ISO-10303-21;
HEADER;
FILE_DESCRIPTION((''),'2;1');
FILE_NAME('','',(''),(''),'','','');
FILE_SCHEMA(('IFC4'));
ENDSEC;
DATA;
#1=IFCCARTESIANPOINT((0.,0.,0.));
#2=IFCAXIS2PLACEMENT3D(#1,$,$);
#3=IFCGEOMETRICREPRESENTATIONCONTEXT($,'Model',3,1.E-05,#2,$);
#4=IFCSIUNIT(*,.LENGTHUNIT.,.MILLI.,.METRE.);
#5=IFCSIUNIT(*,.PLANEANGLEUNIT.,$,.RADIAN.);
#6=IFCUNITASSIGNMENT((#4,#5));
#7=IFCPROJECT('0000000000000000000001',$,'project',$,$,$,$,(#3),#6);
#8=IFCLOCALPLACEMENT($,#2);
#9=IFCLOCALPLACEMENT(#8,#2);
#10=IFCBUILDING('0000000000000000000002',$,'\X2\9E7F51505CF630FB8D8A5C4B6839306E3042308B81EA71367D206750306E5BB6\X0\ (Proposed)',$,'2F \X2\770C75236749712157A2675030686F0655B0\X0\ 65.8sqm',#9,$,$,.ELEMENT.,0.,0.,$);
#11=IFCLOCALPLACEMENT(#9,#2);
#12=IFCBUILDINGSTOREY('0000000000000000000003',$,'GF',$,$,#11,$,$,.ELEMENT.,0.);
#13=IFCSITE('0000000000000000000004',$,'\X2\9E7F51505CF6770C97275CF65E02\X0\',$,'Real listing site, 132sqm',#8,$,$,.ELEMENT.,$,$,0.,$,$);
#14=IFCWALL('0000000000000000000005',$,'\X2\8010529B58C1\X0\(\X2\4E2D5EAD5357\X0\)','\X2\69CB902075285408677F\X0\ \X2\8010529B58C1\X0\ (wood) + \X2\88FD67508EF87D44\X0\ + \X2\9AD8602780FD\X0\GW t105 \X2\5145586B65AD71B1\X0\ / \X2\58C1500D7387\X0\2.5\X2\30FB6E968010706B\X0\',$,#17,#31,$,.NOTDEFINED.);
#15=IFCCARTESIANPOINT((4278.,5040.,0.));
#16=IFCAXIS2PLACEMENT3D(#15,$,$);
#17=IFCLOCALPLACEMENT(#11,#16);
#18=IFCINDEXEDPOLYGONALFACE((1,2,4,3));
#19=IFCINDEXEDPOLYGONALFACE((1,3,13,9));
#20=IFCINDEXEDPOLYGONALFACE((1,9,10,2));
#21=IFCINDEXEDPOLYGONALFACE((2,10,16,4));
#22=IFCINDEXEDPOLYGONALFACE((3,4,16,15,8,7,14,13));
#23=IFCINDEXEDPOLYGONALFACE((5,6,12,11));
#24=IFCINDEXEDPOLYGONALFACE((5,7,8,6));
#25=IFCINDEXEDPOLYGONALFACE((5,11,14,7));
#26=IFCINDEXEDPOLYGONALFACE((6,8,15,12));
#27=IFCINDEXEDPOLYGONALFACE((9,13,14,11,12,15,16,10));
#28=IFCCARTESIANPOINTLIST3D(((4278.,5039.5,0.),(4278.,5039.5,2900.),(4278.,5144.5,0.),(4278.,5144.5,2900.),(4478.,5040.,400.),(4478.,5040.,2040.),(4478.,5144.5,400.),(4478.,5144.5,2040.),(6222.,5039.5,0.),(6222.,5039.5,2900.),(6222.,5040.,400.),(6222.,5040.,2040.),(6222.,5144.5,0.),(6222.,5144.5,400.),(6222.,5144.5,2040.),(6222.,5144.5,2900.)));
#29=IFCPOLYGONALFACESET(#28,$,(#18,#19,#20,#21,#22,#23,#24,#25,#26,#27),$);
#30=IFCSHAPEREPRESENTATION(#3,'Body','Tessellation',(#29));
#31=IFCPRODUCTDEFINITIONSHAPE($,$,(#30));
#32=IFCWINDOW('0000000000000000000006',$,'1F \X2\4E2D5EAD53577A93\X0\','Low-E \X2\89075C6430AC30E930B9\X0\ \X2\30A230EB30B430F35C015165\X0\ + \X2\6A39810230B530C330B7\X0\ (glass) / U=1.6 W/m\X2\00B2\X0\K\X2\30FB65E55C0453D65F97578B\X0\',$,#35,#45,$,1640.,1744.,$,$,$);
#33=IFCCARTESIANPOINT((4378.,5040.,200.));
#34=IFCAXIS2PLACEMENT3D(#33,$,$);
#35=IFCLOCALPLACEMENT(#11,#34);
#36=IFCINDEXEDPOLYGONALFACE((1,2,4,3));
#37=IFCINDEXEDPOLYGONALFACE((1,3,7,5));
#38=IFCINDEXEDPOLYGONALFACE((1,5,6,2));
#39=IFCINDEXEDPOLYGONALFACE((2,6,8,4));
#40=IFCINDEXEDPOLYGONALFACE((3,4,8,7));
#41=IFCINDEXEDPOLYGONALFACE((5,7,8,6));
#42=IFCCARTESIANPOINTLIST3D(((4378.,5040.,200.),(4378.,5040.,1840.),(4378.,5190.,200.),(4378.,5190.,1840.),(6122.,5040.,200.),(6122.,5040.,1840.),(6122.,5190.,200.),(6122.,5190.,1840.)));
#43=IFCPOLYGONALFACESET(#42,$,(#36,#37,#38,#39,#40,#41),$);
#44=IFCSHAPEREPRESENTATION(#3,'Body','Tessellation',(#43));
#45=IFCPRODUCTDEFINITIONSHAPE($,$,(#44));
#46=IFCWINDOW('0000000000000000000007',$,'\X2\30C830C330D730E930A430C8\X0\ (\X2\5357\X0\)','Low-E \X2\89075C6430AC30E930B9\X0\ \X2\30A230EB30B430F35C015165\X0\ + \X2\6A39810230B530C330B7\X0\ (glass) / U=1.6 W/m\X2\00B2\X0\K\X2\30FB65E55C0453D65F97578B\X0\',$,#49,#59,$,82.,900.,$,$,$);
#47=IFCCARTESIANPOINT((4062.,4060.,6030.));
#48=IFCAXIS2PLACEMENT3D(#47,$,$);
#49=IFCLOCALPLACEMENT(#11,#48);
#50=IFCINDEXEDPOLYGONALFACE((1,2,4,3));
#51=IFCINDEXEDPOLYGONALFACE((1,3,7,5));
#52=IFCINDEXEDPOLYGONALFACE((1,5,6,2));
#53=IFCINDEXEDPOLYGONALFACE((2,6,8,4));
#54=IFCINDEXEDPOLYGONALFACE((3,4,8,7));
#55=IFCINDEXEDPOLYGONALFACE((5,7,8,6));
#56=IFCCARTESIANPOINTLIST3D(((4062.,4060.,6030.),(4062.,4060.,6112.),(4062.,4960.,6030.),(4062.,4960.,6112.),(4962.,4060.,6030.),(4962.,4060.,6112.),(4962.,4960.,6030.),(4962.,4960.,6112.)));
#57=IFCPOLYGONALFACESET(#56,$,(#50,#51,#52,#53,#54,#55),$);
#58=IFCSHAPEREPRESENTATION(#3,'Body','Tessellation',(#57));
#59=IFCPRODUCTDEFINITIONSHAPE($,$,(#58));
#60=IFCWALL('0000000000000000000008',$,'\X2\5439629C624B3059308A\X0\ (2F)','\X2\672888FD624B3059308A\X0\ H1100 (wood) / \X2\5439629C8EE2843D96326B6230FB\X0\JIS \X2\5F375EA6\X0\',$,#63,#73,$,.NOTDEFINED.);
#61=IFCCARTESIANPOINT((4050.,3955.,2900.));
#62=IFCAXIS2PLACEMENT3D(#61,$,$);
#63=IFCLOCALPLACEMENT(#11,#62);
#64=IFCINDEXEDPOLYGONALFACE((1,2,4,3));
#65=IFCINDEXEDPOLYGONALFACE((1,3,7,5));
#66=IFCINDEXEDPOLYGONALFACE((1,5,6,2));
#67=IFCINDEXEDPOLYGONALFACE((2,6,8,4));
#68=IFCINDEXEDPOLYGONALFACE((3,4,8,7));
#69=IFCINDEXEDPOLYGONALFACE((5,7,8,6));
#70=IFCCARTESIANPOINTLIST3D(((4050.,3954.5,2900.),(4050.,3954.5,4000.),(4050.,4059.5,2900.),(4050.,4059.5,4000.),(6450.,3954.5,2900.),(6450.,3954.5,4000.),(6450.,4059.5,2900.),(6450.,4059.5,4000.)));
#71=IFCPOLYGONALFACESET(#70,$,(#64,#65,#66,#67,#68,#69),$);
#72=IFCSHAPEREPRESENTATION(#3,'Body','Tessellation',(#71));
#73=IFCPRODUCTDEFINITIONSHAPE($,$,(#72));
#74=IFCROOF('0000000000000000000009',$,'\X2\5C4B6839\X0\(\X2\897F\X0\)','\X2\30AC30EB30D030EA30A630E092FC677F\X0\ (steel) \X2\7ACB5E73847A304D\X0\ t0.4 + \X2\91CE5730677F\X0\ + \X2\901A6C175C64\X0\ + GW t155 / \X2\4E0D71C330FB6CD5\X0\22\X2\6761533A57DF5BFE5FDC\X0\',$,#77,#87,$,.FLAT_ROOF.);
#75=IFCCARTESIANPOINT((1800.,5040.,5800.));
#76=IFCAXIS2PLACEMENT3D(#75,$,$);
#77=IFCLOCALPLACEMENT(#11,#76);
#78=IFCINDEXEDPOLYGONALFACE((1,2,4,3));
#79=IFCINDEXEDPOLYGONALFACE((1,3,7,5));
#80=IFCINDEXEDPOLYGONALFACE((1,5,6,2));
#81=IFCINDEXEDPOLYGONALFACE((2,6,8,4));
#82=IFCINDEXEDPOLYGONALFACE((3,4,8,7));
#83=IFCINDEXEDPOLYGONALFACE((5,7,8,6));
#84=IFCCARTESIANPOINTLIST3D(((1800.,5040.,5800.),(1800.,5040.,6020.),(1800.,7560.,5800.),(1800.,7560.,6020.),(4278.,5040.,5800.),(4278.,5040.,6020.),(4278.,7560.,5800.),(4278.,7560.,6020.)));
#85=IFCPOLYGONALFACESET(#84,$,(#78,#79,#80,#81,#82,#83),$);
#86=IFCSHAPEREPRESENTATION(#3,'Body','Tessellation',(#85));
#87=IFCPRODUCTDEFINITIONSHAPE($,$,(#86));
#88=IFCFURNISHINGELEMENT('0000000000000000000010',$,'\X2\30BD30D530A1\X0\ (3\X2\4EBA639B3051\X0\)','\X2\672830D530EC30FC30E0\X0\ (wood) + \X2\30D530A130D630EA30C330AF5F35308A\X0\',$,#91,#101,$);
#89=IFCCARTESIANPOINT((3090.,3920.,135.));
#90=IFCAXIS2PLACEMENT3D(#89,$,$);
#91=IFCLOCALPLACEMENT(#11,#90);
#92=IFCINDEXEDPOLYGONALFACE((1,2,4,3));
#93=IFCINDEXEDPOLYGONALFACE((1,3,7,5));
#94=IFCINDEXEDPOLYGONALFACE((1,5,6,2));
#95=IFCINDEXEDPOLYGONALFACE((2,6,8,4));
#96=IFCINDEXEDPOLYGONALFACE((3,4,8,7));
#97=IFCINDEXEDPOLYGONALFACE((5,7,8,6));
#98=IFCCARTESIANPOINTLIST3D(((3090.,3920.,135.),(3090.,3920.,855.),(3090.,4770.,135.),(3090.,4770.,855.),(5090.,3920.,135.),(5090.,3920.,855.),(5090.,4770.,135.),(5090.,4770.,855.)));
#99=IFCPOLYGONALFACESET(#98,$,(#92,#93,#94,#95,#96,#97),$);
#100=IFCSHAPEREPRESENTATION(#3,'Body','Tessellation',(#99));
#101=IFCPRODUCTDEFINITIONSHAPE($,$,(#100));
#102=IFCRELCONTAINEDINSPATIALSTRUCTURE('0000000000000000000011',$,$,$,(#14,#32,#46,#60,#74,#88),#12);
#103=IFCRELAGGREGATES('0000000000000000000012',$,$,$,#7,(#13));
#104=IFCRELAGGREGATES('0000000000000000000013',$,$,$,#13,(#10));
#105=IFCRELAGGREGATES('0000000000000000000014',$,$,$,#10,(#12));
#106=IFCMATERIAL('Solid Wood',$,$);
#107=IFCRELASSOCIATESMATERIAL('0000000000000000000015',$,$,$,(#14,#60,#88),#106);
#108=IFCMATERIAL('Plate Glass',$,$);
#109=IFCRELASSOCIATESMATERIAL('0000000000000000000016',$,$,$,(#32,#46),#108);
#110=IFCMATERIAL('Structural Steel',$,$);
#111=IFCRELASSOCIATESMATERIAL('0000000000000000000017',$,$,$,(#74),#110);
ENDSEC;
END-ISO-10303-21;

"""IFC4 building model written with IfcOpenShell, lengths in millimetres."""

from ifc_helpers import new_model, si_unit, frame, frame_2d, origin, place, context, project, spatial, rectangle, extrude, material, element, fill, save


model = new_model("IFC4")

# Units and contexts
model_context = context("Model", 3, precision=1e-05, world=origin())
ifc_project = project(units=[si_unit("LENGTHUNIT", "METRE", prefix="MILLI"), si_unit("PLANEANGLEUNIT", "RADIAN")], contexts=[model_context])

# Site, building, storey
site_placement = place(None, origin())
site = spatial("IfcSite", under=ifc_project, at=site_placement, Name="鹿児島県霧島市", ObjectType="Real listing site, 132sqm", CompositionType="ELEMENT", RefElevation=0.0)
building_placement = place(site_placement, origin())
building = spatial("IfcBuilding", under=site, at=building_placement, Name="鹿児島・越屋根のある自然素材の家 (Proposed)", ObjectType="2F 県産杉無垢材と漆喰 65.8sqm", CompositionType="ELEMENT", ElevationOfRefHeight=0.0, ElevationOfTerrain=0.0)
storey_placement = place(building_placement, origin())
storey = spatial("IfcBuildingStorey", under=building, at=storey_placement, Name="GF", CompositionType="ELEMENT", Elevation=0.0)

# Shared definitions
ifc_material_1 = material(Name="Solid Wood")

# Wall, opening, window
wall_1_placement = place(storey_placement, frame((4278.0, 5040.0, 0.0)))
wall_1 = element("IfcWall", 1, at=wall_1_placement, inside=storey, material=ifc_material_1, Name="耐力壁(中庭南)", Description="構造用合板 耐力壁 (wood) + 製材軸組 + 高性能GW t105 充填断熱 / 壁倍率2.5・準耐火", PredefinedType="NOTDEFINED", context=model_context, shape_type="SweptSolid", body=[
    extrude(rectangle(XDim=1944.0, YDim=105.0, at=frame_2d((972.0, 52.0))), frame((4278.0, 5040.0, 0.0)), (0.0, 0.0, 1.0), 2900.0),
])
opening_placement = place(storey_placement, frame((4378.0, 5040.0, 200.0)))
opening = element("IfcOpeningElement", 2, at=opening_placement, cuts=wall_1, PredefinedType="NOTDEFINED", context=model_context, shape_type="SweptSolid", body=[
    extrude(rectangle(XDim=1744.0, YDim=150.0, at=frame_2d((872.0, 75.0))), frame((4378.0, 5040.0, 200.0)), (0.0, 0.0, 1.0), 1640.0),
])
ifc_material_2 = material(Name="Plate Glass")
window_1_placement = place(storey_placement, frame((4378.0, 5040.0, 200.0)))
window_1 = element("IfcWindow", 3, at=window_1_placement, inside=storey, material=ifc_material_2, Name="1F 中庭南窓", Description="Low-E 複層ガラス アルゴン封入 + 樹脂サッシ (glass) / U=1.6 W/m²K・日射取得型", OverallHeight=1640.0, OverallWidth=1744.0, context=model_context, shape_type="SweptSolid", body=[
    extrude(rectangle(XDim=1744.0, YDim=150.0, at=frame_2d((872.0, 75.0))), frame((4378.0, 5040.0, 200.0)), (0.0, 0.0, 1.0), 1640.0),
])
fill(opening, window_1)

# Window
window_2_placement = place(storey_placement, frame((4062.0, 4060.0, 6030.0)))
element("IfcWindow", 4, at=window_2_placement, inside=storey, material=ifc_material_2, Name="トップライト (南)", Description="Low-E 複層ガラス アルゴン封入 + 樹脂サッシ (glass) / U=1.6 W/m²K・日射取得型", OverallHeight=82.0, OverallWidth=900.0, context=model_context, shape_type="SweptSolid", body=[
    extrude(rectangle(XDim=900.0, YDim=900.0, at=frame_2d((450.0, 450.0))), frame((4062.0, 4060.0, 6030.0)), (0.0, 0.0, 1.0), 82.0),
])

# Wall
wall_2_placement = place(storey_placement, frame((4050.0, 3955.0, 2900.0)))
element("IfcWall", 5, at=wall_2_placement, inside=storey, material=ifc_material_1, Name="吹抜手すり (2F)", Description="木製手すり H1100 (wood) / 吹抜転落防止・JIS 強度", PredefinedType="NOTDEFINED", context=model_context, shape_type="SweptSolid", body=[
    extrude(rectangle(XDim=2400.0, YDim=105.0, at=frame_2d((1200.0, 52.0))), frame((4050.0, 3955.0, 2900.0)), (0.0, 0.0, 1.0), 1100.0),
])

# Roof
ifc_material_3 = material(Name="Structural Steel")
for number, where, name in (
    (6, (1800.0, 5040.0, 5800.0), "屋根(西)"),
):
    element("IfcRoof", number, at=place(storey_placement, frame(where)), inside=storey, material=ifc_material_3, Name=name, Description="ガルバリウム鋼板 (steel) 立平葺き t0.4 + 野地板 + 通気層 + GW t155 / 不燃・法22条区域対応", PredefinedType="FLAT_ROOF", context=model_context, shape_type="SweptSolid", body=[
        extrude(rectangle(XDim=2478.0, YDim=2520.0, at=frame_2d((1239.0, 1260.0))), frame((1800.0, 5040.0, 5800.0)), (0.0, 0.0, 1.0), 220.0),
    ])

# Furnishing element
furnishing_placement = place(storey_placement, frame((3090.0, 3920.0, 135.0)))
element("IfcFurnishingElement", 7, at=furnishing_placement, inside=storey, material=ifc_material_1, Name="ソファ (3人掛け)", Description="木フレーム (wood) + ファブリック張り", context=model_context, shape_type="SweptSolid", body=[
    extrude(rectangle(XDim=2000.0, YDim=850.0, at=frame_2d((1000.0, 425.0))), frame((3090.0, 3920.0, 135.0)), (0.0, 0.0, 1.0), 720.0),
])

save(model, "model.ifc")
